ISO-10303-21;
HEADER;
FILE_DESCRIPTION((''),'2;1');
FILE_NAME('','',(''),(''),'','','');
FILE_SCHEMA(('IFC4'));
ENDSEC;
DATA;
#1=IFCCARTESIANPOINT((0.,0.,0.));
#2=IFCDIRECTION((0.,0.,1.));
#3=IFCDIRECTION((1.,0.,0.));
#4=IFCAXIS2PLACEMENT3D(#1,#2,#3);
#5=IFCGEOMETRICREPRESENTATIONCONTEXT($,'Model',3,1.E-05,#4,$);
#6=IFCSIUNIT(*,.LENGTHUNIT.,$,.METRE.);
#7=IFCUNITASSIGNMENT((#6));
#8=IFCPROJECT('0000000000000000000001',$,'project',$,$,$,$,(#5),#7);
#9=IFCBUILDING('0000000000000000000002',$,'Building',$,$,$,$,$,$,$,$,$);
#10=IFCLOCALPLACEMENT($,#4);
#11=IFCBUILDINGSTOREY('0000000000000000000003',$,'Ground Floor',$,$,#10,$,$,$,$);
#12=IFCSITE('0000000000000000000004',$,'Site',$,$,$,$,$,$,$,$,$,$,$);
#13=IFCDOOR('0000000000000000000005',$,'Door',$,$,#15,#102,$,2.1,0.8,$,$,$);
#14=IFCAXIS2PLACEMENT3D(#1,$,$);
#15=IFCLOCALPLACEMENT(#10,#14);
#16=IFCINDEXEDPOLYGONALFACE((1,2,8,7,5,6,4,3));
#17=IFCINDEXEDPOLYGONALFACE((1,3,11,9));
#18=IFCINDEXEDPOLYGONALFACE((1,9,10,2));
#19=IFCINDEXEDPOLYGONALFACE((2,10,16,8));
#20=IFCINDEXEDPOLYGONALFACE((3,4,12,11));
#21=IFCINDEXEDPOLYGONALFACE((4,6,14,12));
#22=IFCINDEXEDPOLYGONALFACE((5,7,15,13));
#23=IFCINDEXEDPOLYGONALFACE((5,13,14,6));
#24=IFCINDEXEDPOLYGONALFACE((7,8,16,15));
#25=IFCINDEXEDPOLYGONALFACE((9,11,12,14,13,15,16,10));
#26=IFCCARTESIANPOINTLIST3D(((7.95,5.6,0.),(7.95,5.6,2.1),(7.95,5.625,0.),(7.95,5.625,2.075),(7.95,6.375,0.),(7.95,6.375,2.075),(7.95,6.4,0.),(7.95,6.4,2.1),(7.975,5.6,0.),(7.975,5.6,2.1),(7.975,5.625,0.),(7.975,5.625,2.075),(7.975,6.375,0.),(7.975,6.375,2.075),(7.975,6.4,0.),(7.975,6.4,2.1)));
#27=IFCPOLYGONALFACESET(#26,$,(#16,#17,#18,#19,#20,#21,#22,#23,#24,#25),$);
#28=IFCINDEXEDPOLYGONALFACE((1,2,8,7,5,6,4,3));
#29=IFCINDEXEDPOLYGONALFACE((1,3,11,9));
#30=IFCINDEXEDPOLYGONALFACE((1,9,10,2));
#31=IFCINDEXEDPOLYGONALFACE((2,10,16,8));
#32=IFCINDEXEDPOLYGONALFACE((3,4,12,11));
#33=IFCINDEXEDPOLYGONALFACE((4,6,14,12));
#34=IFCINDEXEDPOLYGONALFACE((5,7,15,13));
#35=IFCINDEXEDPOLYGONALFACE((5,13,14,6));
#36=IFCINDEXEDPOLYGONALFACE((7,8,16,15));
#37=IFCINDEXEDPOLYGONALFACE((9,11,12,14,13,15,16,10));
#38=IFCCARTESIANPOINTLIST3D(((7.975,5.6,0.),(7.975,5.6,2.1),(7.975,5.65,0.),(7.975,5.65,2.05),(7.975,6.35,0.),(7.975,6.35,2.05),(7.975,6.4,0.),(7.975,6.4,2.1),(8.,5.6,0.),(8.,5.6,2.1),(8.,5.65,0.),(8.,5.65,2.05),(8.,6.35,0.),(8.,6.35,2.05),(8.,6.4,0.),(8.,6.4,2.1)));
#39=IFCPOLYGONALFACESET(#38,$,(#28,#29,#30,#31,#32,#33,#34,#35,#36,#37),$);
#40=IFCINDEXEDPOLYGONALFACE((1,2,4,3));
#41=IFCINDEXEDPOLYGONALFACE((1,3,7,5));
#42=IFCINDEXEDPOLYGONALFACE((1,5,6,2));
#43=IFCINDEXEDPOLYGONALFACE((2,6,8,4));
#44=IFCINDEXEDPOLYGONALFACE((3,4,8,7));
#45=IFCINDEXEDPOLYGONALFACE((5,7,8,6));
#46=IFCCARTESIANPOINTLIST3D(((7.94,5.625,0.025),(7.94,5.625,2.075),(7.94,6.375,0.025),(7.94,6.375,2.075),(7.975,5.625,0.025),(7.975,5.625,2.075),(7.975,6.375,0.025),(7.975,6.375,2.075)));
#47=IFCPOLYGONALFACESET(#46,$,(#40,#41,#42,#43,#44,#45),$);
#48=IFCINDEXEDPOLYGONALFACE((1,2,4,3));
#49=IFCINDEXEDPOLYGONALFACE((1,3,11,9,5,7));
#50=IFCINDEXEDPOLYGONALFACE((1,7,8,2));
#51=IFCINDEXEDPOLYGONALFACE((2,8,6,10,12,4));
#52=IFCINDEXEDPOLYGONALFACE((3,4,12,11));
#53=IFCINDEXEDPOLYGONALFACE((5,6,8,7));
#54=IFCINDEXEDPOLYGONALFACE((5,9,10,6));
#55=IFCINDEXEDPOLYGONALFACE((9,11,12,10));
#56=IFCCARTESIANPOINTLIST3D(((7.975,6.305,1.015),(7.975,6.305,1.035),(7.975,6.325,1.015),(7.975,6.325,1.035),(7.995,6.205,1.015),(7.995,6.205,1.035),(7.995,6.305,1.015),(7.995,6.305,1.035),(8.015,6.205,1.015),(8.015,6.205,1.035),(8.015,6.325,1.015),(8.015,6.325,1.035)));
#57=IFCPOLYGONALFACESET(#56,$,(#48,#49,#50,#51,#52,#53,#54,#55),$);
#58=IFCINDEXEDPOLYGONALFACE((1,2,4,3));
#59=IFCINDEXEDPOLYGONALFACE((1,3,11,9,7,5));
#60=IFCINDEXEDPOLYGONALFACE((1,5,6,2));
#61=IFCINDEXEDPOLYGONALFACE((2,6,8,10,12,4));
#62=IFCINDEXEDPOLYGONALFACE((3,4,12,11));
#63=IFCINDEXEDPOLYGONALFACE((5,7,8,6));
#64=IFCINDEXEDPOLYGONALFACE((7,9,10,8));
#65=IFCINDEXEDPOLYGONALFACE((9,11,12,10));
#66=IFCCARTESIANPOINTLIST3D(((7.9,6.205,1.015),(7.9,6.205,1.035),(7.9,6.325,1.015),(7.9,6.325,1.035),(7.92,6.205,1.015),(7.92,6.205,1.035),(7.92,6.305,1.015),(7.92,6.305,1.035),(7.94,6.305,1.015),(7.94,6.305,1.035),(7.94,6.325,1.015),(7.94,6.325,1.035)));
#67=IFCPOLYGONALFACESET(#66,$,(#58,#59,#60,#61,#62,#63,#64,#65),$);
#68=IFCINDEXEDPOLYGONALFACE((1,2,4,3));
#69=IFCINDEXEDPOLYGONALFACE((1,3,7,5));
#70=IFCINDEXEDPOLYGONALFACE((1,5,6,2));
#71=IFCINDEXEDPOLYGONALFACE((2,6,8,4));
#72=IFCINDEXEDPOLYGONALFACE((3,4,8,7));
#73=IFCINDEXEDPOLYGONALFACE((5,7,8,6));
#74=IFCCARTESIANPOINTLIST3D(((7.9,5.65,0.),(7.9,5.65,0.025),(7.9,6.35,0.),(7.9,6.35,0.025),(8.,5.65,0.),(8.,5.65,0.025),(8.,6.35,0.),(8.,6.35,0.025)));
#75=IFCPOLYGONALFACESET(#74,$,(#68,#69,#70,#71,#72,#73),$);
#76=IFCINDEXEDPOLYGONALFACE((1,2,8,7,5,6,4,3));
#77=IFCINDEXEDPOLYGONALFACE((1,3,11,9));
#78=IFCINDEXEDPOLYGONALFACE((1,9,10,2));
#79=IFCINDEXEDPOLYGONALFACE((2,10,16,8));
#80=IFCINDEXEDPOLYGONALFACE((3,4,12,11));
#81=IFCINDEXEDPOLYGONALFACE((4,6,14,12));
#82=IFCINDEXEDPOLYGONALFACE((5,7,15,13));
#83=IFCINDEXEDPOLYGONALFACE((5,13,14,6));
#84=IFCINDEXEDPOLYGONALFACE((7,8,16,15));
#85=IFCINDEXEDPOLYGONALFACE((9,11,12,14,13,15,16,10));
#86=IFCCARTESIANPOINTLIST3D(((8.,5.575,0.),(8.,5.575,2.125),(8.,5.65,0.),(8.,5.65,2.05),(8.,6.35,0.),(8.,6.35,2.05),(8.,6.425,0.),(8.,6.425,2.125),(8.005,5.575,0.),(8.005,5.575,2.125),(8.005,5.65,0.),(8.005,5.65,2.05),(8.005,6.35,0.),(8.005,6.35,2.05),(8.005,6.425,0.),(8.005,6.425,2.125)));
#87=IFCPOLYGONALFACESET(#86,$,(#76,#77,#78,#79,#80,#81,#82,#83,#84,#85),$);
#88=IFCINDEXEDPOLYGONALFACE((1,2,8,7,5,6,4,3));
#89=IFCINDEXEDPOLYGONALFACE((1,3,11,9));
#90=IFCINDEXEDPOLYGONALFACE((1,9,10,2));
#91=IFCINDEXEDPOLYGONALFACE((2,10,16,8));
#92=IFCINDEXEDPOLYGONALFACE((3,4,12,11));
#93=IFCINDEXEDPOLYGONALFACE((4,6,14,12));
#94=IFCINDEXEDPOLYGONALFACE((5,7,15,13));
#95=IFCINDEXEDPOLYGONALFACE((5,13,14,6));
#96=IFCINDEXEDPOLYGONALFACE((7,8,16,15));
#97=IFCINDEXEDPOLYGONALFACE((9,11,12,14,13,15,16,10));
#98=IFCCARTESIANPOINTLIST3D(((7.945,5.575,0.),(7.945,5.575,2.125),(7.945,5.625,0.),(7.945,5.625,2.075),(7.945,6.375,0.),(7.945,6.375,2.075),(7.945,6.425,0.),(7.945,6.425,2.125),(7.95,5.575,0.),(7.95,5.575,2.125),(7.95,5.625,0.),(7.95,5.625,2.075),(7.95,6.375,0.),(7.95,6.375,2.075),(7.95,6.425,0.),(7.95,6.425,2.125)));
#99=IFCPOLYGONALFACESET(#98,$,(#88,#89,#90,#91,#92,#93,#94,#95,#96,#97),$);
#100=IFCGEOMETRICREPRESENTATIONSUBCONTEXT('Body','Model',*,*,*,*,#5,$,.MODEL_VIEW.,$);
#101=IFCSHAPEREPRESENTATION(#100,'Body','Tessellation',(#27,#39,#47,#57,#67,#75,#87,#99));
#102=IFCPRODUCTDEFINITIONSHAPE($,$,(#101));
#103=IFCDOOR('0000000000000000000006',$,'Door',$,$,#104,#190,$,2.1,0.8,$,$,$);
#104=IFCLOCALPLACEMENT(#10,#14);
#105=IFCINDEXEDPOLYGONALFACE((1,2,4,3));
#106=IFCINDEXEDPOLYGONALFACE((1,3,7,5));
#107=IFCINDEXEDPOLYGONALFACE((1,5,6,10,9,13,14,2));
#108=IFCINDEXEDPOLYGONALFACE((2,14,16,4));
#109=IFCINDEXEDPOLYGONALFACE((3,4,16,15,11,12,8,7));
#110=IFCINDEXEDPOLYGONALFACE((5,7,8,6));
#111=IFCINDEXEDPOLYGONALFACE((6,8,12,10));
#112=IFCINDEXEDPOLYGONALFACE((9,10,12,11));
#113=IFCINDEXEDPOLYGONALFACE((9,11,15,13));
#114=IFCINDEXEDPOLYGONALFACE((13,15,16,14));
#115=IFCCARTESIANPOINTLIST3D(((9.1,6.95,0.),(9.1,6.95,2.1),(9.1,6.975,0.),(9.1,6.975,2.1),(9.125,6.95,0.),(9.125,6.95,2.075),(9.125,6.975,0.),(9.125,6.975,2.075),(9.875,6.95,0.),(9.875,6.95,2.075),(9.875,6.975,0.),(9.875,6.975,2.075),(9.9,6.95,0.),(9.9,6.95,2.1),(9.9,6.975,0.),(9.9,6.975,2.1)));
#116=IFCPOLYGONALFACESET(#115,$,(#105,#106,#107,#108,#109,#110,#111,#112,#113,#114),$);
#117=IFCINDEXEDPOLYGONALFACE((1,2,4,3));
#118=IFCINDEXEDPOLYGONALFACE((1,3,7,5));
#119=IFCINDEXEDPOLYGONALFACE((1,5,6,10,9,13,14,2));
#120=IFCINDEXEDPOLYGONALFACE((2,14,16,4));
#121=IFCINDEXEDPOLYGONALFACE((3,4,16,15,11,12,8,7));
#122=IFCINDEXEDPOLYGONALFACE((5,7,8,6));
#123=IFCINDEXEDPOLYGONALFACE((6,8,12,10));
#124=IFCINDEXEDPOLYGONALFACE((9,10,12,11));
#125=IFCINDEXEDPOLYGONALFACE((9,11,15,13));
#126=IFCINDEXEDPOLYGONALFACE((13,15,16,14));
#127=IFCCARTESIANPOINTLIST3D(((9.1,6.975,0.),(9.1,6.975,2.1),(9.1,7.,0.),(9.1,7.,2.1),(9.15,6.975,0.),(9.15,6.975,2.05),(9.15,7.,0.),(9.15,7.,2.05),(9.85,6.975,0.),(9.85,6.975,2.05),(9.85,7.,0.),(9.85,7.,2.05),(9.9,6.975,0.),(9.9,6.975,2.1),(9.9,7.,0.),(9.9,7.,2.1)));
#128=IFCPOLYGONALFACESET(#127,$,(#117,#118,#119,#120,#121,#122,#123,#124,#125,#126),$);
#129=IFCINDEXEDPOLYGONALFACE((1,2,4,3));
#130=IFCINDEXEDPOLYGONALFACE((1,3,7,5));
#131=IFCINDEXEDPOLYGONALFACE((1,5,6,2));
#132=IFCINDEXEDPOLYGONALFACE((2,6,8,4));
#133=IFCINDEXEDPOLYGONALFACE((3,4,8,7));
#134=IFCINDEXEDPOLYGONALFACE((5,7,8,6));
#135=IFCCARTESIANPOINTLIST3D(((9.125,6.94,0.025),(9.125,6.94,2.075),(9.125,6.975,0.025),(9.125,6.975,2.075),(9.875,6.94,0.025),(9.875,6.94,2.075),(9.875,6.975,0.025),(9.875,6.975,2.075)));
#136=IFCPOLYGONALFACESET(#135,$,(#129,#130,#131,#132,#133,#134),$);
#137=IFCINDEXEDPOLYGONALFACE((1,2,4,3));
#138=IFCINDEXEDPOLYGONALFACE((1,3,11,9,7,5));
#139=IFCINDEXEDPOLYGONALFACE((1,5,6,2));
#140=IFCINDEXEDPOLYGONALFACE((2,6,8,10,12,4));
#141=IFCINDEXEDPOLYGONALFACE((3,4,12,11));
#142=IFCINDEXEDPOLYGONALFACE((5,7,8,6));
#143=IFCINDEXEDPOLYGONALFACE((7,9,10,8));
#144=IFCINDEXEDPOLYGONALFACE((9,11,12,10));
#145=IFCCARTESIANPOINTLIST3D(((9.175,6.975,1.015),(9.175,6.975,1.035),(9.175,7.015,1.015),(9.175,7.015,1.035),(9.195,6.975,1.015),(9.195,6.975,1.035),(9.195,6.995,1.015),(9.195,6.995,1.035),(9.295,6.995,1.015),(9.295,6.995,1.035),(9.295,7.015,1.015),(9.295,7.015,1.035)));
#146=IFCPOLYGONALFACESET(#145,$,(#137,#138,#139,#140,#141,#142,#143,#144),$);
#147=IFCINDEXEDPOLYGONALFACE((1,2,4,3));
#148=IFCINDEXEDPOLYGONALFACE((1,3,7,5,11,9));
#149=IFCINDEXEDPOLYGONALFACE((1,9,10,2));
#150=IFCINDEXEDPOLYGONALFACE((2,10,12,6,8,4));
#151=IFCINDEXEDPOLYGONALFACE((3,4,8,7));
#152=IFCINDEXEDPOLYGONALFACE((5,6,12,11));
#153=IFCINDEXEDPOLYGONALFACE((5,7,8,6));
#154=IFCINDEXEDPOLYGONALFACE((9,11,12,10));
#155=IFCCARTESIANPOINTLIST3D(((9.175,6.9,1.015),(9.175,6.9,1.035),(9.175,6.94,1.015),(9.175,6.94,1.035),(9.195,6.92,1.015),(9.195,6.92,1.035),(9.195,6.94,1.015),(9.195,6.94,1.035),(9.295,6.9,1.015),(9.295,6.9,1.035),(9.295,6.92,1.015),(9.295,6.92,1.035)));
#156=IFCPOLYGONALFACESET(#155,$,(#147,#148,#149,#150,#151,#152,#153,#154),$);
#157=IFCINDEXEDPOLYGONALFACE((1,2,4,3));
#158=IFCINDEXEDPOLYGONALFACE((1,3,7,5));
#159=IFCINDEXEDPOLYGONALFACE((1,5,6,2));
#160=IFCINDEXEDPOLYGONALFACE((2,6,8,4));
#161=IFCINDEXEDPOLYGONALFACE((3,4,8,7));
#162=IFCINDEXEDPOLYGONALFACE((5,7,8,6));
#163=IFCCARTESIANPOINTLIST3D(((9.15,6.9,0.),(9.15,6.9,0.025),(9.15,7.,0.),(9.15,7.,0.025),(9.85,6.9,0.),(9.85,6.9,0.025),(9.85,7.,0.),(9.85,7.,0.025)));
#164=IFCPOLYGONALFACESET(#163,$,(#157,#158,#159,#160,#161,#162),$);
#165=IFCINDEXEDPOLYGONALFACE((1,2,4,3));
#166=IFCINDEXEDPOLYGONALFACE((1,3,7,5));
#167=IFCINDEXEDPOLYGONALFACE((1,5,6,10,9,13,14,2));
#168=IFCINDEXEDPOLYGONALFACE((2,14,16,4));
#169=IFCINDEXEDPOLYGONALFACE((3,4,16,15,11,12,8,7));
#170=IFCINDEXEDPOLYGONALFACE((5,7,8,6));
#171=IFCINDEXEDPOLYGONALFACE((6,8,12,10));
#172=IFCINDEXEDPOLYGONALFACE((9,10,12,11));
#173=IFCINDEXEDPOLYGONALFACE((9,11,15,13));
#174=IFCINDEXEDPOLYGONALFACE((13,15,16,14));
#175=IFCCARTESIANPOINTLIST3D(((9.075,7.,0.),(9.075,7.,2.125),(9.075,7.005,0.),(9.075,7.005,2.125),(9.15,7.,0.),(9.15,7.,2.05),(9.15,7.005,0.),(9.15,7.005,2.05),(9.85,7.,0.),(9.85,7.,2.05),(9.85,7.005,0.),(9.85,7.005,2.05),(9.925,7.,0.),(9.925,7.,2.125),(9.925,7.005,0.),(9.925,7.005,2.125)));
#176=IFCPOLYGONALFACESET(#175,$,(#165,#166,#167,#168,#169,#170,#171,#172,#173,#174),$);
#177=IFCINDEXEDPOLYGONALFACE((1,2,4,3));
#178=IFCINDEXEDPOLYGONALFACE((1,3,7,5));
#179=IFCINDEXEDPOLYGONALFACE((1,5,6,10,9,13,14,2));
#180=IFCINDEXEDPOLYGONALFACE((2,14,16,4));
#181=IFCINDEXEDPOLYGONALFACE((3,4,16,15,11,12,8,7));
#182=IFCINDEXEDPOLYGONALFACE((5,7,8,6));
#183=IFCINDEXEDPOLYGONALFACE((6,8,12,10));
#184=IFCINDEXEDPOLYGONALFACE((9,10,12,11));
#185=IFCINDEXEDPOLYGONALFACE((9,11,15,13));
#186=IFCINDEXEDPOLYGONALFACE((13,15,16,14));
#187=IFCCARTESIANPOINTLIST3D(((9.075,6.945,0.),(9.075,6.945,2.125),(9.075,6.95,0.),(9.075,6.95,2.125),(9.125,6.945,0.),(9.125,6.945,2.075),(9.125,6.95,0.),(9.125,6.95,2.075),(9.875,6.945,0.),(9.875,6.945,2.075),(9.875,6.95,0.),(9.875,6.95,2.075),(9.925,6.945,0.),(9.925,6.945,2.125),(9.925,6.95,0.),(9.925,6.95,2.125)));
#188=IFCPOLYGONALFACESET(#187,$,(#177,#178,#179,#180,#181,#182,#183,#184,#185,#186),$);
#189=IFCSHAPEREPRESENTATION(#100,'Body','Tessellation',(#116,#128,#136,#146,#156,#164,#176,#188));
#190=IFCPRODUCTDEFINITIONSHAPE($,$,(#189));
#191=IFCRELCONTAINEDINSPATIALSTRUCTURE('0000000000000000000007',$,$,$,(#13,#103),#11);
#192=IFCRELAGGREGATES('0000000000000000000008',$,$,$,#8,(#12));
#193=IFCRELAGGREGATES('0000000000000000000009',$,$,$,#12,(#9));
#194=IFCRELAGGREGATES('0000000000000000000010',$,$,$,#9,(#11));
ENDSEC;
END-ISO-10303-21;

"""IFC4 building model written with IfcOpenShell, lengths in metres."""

from ifc_helpers import new_model, si_unit, frame, origin_with_axes, place, context, subcontext, project, spatial, line, indexed_curve, outline, extrude, element, save


model = new_model("IFC4")

# Units and contexts
model_context = context("Model", 3, precision=1e-05, world=origin_with_axes())
body_context = subcontext(model_context, "Body", "Model", "MODEL_VIEW")
ifc_project = project(units=[si_unit("LENGTHUNIT", "METRE")], contexts=[model_context])

# Site, building, storey
site = spatial("IfcSite", under=ifc_project, Name="Site")
building = spatial("IfcBuilding", under=site, Name="Building")
storey_placement = place(None, origin_with_axes())
storey = spatial("IfcBuildingStorey", under=building, at=storey_placement, Name="Ground Floor")

# Doors
door_1_placement = place(storey_placement, frame((8.0, 5.6, 0.0), z_axis=(0.0, 0.0, 1.0), x_axis=(0.0, 1.0, 0.0)))
element("IfcDoor", 1, at=door_1_placement, inside=storey, Name="Door", OverallHeight=2.1, OverallWidth=0.8, context=body_context, shape_type="SweptSolid", body=[
    extrude(outline(indexed_curve([(0.0, 0.0), (0.0, 2.1), (0.8, 2.1), (0.8, 0.0), (0.775, 0.0), (0.775, 2.075), (0.025, 2.075), (0.025, 0.0)], segments=[line(1, 2, 3, 4, 5, 6, 7, 8, 1)])), frame((0.0, 0.025, 0.0), z_axis=(0.0, -1.0, 0.0), x_axis=(1.0, 0.0, 0.0)), (0.0, 0.0, -1.0), 0.025),
    extrude(outline(indexed_curve([(0.0, 0.0), (0.0, 2.1), (0.8, 2.1), (0.8, 0.0), (0.75, 0.0), (0.75, 2.05), (0.05, 2.05), (0.05, 0.0)], segments=[line(1, 2, 3, 4, 5, 6, 7, 8, 1)])), frame((0.0, 0.0, 0.0), z_axis=(0.0, -1.0, 0.0), x_axis=(1.0, 0.0, 0.0)), (0.0, 0.0, -1.0), 0.025),
    extrude(outline(indexed_curve([(0.0, 0.0), (0.75, 0.0), (0.75, 0.035), (0.0, 0.035)], segments=[line(1, 2, 3, 4, 1)])), frame((0.025, 0.025, 0.025), z_axis=(0.0, 0.0, 1.0), x_axis=(1.0, 0.0, 0.0)), (0.0, 0.0, 1.0), 2.05),
    extrude(outline(indexed_curve([(0.0, 0.0), (0.0, -0.04), (-0.12, -0.04), (-0.12, -0.02), (-0.02, -0.02), (-0.02, 0.0)], segments=[line(1, 2, 3, 4, 5, 6, 1)])), frame((0.725, 0.025, 1.015), z_axis=(0.0, 0.0, 1.0), x_axis=(1.0, 0.0, 0.0)), (0.0, 0.0, 1.0), 0.02),
    extrude(outline(indexed_curve([(0.0, 0.0), (0.0, 0.04), (-0.12, 0.04), (-0.12, 0.02), (-0.02, 0.02), (-0.02, 0.0)], segments=[line(1, 2, 3, 4, 5, 6, 1)])), frame((0.725, 0.06, 1.015), z_axis=(0.0, 0.0, 1.0), x_axis=(1.0, 0.0, 0.0)), (0.0, 0.0, 1.0), 0.02),
    extrude(outline(indexed_curve([(0.0, 0.0), (0.7, 0.0), (0.7, 0.1), (0.0, 0.1)], segments=[line(1, 2, 3, 4, 1)])), frame((0.05, 0.0, 0.0), z_axis=(0.0, 0.0, 1.0), x_axis=(1.0, 0.0, 0.0)), (0.0, 0.0, 1.0), 0.025),
    extrude(outline(indexed_curve([(0.0, 0.0), (0.0, 2.125), (0.85, 2.125), (0.85, 0.0), (0.775, 0.0), (0.775, 2.05), (0.075, 2.05), (0.075, 0.0)], segments=[line(1, 2, 3, 4, 5, 6, 7, 8, 1)])), frame((-0.025, -0.005, 0.0), z_axis=(0.0, -1.0, 0.0), x_axis=(1.0, 0.0, 0.0)), (0.0, 0.0, -1.0), 0.005),
    extrude(outline(indexed_curve([(0.0, 0.0), (0.0, 2.125), (0.85, 2.125), (0.85, 0.0), (0.8, 0.0), (0.8, 2.075), (0.05, 2.075), (0.05, 0.0)], segments=[line(1, 2, 3, 4, 5, 6, 7, 8, 1)])), frame((-0.025, 0.05, 0.0), z_axis=(0.0, -1.0, 0.0), x_axis=(1.0, 0.0, 0.0)), (0.0, 0.0, -1.0), 0.005),
])
door_2_placement = place(storey_placement, frame((9.9, 7.0, 0.0), z_axis=(0.0, 0.0, 1.0), x_axis=(-1.0, 0.0, 0.0)))
element("IfcDoor", 2, at=door_2_placement, inside=storey, Name="Door", OverallHeight=2.1, OverallWidth=0.8, context=body_context, shape_type="SweptSolid", body=[
    extrude(outline(indexed_curve([(0.0, 0.0), (0.0, 2.1), (0.8, 2.1), (0.8, 0.0), (0.775, 0.0), (0.775, 2.075), (0.025, 2.075), (0.025, 0.0)], segments=[line(1, 2, 3, 4, 5, 6, 7, 8, 1)])), frame((0.0, 0.025, 0.0), z_axis=(0.0, -1.0, 0.0), x_axis=(1.0, 0.0, 0.0)), (0.0, 0.0, -1.0), 0.025),
    extrude(outline(indexed_curve([(0.0, 0.0), (0.0, 2.1), (0.8, 2.1), (0.8, 0.0), (0.75, 0.0), (0.75, 2.05), (0.05, 2.05), (0.05, 0.0)], segments=[line(1, 2, 3, 4, 5, 6, 7, 8, 1)])), frame((0.0, 0.0, 0.0), z_axis=(0.0, -1.0, 0.0), x_axis=(1.0, 0.0, 0.0)), (0.0, 0.0, -1.0), 0.025),
    extrude(outline(indexed_curve([(0.0, 0.0), (0.75, 0.0), (0.75, 0.035), (0.0, 0.035)], segments=[line(1, 2, 3, 4, 1)])), frame((0.025, 0.025, 0.025), z_axis=(0.0, 0.0, 1.0), x_axis=(1.0, 0.0, 0.0)), (0.0, 0.0, 1.0), 2.05),
    extrude(outline(indexed_curve([(0.0, 0.0), (0.0, -0.04), (-0.12, -0.04), (-0.12, -0.02), (-0.02, -0.02), (-0.02, 0.0)], segments=[line(1, 2, 3, 4, 5, 6, 1)])), frame((0.725, 0.025, 1.015), z_axis=(0.0, 0.0, 1.0), x_axis=(1.0, 0.0, 0.0)), (0.0, 0.0, 1.0), 0.02),
    extrude(outline(indexed_curve([(0.0, 0.0), (0.0, 0.04), (-0.12, 0.04), (-0.12, 0.02), (-0.02, 0.02), (-0.02, 0.0)], segments=[line(1, 2, 3, 4, 5, 6, 1)])), frame((0.725, 0.06, 1.015), z_axis=(0.0, 0.0, 1.0), x_axis=(1.0, 0.0, 0.0)), (0.0, 0.0, 1.0), 0.02),
    extrude(outline(indexed_curve([(0.0, 0.0), (0.7, 0.0), (0.7, 0.1), (0.0, 0.1)], segments=[line(1, 2, 3, 4, 1)])), frame((0.05, 0.0, 0.0), z_axis=(0.0, 0.0, 1.0), x_axis=(1.0, 0.0, 0.0)), (0.0, 0.0, 1.0), 0.025),
    extrude(outline(indexed_curve([(0.0, 0.0), (0.0, 2.125), (0.85, 2.125), (0.85, 0.0), (0.775, 0.0), (0.775, 2.05), (0.075, 2.05), (0.075, 0.0)], segments=[line(1, 2, 3, 4, 5, 6, 7, 8, 1)])), frame((-0.025, -0.005, 0.0), z_axis=(0.0, -1.0, 0.0), x_axis=(1.0, 0.0, 0.0)), (0.0, 0.0, -1.0), 0.005),
    extrude(outline(indexed_curve([(0.0, 0.0), (0.0, 2.125), (0.85, 2.125), (0.85, 0.0), (0.8, 0.0), (0.8, 2.075), (0.05, 2.075), (0.05, 0.0)], segments=[line(1, 2, 3, 4, 5, 6, 7, 8, 1)])), frame((-0.025, 0.05, 0.0), z_axis=(0.0, -1.0, 0.0), x_axis=(1.0, 0.0, 0.0)), (0.0, 0.0, -1.0), 0.005),
])

save(model, "model.ifc")
